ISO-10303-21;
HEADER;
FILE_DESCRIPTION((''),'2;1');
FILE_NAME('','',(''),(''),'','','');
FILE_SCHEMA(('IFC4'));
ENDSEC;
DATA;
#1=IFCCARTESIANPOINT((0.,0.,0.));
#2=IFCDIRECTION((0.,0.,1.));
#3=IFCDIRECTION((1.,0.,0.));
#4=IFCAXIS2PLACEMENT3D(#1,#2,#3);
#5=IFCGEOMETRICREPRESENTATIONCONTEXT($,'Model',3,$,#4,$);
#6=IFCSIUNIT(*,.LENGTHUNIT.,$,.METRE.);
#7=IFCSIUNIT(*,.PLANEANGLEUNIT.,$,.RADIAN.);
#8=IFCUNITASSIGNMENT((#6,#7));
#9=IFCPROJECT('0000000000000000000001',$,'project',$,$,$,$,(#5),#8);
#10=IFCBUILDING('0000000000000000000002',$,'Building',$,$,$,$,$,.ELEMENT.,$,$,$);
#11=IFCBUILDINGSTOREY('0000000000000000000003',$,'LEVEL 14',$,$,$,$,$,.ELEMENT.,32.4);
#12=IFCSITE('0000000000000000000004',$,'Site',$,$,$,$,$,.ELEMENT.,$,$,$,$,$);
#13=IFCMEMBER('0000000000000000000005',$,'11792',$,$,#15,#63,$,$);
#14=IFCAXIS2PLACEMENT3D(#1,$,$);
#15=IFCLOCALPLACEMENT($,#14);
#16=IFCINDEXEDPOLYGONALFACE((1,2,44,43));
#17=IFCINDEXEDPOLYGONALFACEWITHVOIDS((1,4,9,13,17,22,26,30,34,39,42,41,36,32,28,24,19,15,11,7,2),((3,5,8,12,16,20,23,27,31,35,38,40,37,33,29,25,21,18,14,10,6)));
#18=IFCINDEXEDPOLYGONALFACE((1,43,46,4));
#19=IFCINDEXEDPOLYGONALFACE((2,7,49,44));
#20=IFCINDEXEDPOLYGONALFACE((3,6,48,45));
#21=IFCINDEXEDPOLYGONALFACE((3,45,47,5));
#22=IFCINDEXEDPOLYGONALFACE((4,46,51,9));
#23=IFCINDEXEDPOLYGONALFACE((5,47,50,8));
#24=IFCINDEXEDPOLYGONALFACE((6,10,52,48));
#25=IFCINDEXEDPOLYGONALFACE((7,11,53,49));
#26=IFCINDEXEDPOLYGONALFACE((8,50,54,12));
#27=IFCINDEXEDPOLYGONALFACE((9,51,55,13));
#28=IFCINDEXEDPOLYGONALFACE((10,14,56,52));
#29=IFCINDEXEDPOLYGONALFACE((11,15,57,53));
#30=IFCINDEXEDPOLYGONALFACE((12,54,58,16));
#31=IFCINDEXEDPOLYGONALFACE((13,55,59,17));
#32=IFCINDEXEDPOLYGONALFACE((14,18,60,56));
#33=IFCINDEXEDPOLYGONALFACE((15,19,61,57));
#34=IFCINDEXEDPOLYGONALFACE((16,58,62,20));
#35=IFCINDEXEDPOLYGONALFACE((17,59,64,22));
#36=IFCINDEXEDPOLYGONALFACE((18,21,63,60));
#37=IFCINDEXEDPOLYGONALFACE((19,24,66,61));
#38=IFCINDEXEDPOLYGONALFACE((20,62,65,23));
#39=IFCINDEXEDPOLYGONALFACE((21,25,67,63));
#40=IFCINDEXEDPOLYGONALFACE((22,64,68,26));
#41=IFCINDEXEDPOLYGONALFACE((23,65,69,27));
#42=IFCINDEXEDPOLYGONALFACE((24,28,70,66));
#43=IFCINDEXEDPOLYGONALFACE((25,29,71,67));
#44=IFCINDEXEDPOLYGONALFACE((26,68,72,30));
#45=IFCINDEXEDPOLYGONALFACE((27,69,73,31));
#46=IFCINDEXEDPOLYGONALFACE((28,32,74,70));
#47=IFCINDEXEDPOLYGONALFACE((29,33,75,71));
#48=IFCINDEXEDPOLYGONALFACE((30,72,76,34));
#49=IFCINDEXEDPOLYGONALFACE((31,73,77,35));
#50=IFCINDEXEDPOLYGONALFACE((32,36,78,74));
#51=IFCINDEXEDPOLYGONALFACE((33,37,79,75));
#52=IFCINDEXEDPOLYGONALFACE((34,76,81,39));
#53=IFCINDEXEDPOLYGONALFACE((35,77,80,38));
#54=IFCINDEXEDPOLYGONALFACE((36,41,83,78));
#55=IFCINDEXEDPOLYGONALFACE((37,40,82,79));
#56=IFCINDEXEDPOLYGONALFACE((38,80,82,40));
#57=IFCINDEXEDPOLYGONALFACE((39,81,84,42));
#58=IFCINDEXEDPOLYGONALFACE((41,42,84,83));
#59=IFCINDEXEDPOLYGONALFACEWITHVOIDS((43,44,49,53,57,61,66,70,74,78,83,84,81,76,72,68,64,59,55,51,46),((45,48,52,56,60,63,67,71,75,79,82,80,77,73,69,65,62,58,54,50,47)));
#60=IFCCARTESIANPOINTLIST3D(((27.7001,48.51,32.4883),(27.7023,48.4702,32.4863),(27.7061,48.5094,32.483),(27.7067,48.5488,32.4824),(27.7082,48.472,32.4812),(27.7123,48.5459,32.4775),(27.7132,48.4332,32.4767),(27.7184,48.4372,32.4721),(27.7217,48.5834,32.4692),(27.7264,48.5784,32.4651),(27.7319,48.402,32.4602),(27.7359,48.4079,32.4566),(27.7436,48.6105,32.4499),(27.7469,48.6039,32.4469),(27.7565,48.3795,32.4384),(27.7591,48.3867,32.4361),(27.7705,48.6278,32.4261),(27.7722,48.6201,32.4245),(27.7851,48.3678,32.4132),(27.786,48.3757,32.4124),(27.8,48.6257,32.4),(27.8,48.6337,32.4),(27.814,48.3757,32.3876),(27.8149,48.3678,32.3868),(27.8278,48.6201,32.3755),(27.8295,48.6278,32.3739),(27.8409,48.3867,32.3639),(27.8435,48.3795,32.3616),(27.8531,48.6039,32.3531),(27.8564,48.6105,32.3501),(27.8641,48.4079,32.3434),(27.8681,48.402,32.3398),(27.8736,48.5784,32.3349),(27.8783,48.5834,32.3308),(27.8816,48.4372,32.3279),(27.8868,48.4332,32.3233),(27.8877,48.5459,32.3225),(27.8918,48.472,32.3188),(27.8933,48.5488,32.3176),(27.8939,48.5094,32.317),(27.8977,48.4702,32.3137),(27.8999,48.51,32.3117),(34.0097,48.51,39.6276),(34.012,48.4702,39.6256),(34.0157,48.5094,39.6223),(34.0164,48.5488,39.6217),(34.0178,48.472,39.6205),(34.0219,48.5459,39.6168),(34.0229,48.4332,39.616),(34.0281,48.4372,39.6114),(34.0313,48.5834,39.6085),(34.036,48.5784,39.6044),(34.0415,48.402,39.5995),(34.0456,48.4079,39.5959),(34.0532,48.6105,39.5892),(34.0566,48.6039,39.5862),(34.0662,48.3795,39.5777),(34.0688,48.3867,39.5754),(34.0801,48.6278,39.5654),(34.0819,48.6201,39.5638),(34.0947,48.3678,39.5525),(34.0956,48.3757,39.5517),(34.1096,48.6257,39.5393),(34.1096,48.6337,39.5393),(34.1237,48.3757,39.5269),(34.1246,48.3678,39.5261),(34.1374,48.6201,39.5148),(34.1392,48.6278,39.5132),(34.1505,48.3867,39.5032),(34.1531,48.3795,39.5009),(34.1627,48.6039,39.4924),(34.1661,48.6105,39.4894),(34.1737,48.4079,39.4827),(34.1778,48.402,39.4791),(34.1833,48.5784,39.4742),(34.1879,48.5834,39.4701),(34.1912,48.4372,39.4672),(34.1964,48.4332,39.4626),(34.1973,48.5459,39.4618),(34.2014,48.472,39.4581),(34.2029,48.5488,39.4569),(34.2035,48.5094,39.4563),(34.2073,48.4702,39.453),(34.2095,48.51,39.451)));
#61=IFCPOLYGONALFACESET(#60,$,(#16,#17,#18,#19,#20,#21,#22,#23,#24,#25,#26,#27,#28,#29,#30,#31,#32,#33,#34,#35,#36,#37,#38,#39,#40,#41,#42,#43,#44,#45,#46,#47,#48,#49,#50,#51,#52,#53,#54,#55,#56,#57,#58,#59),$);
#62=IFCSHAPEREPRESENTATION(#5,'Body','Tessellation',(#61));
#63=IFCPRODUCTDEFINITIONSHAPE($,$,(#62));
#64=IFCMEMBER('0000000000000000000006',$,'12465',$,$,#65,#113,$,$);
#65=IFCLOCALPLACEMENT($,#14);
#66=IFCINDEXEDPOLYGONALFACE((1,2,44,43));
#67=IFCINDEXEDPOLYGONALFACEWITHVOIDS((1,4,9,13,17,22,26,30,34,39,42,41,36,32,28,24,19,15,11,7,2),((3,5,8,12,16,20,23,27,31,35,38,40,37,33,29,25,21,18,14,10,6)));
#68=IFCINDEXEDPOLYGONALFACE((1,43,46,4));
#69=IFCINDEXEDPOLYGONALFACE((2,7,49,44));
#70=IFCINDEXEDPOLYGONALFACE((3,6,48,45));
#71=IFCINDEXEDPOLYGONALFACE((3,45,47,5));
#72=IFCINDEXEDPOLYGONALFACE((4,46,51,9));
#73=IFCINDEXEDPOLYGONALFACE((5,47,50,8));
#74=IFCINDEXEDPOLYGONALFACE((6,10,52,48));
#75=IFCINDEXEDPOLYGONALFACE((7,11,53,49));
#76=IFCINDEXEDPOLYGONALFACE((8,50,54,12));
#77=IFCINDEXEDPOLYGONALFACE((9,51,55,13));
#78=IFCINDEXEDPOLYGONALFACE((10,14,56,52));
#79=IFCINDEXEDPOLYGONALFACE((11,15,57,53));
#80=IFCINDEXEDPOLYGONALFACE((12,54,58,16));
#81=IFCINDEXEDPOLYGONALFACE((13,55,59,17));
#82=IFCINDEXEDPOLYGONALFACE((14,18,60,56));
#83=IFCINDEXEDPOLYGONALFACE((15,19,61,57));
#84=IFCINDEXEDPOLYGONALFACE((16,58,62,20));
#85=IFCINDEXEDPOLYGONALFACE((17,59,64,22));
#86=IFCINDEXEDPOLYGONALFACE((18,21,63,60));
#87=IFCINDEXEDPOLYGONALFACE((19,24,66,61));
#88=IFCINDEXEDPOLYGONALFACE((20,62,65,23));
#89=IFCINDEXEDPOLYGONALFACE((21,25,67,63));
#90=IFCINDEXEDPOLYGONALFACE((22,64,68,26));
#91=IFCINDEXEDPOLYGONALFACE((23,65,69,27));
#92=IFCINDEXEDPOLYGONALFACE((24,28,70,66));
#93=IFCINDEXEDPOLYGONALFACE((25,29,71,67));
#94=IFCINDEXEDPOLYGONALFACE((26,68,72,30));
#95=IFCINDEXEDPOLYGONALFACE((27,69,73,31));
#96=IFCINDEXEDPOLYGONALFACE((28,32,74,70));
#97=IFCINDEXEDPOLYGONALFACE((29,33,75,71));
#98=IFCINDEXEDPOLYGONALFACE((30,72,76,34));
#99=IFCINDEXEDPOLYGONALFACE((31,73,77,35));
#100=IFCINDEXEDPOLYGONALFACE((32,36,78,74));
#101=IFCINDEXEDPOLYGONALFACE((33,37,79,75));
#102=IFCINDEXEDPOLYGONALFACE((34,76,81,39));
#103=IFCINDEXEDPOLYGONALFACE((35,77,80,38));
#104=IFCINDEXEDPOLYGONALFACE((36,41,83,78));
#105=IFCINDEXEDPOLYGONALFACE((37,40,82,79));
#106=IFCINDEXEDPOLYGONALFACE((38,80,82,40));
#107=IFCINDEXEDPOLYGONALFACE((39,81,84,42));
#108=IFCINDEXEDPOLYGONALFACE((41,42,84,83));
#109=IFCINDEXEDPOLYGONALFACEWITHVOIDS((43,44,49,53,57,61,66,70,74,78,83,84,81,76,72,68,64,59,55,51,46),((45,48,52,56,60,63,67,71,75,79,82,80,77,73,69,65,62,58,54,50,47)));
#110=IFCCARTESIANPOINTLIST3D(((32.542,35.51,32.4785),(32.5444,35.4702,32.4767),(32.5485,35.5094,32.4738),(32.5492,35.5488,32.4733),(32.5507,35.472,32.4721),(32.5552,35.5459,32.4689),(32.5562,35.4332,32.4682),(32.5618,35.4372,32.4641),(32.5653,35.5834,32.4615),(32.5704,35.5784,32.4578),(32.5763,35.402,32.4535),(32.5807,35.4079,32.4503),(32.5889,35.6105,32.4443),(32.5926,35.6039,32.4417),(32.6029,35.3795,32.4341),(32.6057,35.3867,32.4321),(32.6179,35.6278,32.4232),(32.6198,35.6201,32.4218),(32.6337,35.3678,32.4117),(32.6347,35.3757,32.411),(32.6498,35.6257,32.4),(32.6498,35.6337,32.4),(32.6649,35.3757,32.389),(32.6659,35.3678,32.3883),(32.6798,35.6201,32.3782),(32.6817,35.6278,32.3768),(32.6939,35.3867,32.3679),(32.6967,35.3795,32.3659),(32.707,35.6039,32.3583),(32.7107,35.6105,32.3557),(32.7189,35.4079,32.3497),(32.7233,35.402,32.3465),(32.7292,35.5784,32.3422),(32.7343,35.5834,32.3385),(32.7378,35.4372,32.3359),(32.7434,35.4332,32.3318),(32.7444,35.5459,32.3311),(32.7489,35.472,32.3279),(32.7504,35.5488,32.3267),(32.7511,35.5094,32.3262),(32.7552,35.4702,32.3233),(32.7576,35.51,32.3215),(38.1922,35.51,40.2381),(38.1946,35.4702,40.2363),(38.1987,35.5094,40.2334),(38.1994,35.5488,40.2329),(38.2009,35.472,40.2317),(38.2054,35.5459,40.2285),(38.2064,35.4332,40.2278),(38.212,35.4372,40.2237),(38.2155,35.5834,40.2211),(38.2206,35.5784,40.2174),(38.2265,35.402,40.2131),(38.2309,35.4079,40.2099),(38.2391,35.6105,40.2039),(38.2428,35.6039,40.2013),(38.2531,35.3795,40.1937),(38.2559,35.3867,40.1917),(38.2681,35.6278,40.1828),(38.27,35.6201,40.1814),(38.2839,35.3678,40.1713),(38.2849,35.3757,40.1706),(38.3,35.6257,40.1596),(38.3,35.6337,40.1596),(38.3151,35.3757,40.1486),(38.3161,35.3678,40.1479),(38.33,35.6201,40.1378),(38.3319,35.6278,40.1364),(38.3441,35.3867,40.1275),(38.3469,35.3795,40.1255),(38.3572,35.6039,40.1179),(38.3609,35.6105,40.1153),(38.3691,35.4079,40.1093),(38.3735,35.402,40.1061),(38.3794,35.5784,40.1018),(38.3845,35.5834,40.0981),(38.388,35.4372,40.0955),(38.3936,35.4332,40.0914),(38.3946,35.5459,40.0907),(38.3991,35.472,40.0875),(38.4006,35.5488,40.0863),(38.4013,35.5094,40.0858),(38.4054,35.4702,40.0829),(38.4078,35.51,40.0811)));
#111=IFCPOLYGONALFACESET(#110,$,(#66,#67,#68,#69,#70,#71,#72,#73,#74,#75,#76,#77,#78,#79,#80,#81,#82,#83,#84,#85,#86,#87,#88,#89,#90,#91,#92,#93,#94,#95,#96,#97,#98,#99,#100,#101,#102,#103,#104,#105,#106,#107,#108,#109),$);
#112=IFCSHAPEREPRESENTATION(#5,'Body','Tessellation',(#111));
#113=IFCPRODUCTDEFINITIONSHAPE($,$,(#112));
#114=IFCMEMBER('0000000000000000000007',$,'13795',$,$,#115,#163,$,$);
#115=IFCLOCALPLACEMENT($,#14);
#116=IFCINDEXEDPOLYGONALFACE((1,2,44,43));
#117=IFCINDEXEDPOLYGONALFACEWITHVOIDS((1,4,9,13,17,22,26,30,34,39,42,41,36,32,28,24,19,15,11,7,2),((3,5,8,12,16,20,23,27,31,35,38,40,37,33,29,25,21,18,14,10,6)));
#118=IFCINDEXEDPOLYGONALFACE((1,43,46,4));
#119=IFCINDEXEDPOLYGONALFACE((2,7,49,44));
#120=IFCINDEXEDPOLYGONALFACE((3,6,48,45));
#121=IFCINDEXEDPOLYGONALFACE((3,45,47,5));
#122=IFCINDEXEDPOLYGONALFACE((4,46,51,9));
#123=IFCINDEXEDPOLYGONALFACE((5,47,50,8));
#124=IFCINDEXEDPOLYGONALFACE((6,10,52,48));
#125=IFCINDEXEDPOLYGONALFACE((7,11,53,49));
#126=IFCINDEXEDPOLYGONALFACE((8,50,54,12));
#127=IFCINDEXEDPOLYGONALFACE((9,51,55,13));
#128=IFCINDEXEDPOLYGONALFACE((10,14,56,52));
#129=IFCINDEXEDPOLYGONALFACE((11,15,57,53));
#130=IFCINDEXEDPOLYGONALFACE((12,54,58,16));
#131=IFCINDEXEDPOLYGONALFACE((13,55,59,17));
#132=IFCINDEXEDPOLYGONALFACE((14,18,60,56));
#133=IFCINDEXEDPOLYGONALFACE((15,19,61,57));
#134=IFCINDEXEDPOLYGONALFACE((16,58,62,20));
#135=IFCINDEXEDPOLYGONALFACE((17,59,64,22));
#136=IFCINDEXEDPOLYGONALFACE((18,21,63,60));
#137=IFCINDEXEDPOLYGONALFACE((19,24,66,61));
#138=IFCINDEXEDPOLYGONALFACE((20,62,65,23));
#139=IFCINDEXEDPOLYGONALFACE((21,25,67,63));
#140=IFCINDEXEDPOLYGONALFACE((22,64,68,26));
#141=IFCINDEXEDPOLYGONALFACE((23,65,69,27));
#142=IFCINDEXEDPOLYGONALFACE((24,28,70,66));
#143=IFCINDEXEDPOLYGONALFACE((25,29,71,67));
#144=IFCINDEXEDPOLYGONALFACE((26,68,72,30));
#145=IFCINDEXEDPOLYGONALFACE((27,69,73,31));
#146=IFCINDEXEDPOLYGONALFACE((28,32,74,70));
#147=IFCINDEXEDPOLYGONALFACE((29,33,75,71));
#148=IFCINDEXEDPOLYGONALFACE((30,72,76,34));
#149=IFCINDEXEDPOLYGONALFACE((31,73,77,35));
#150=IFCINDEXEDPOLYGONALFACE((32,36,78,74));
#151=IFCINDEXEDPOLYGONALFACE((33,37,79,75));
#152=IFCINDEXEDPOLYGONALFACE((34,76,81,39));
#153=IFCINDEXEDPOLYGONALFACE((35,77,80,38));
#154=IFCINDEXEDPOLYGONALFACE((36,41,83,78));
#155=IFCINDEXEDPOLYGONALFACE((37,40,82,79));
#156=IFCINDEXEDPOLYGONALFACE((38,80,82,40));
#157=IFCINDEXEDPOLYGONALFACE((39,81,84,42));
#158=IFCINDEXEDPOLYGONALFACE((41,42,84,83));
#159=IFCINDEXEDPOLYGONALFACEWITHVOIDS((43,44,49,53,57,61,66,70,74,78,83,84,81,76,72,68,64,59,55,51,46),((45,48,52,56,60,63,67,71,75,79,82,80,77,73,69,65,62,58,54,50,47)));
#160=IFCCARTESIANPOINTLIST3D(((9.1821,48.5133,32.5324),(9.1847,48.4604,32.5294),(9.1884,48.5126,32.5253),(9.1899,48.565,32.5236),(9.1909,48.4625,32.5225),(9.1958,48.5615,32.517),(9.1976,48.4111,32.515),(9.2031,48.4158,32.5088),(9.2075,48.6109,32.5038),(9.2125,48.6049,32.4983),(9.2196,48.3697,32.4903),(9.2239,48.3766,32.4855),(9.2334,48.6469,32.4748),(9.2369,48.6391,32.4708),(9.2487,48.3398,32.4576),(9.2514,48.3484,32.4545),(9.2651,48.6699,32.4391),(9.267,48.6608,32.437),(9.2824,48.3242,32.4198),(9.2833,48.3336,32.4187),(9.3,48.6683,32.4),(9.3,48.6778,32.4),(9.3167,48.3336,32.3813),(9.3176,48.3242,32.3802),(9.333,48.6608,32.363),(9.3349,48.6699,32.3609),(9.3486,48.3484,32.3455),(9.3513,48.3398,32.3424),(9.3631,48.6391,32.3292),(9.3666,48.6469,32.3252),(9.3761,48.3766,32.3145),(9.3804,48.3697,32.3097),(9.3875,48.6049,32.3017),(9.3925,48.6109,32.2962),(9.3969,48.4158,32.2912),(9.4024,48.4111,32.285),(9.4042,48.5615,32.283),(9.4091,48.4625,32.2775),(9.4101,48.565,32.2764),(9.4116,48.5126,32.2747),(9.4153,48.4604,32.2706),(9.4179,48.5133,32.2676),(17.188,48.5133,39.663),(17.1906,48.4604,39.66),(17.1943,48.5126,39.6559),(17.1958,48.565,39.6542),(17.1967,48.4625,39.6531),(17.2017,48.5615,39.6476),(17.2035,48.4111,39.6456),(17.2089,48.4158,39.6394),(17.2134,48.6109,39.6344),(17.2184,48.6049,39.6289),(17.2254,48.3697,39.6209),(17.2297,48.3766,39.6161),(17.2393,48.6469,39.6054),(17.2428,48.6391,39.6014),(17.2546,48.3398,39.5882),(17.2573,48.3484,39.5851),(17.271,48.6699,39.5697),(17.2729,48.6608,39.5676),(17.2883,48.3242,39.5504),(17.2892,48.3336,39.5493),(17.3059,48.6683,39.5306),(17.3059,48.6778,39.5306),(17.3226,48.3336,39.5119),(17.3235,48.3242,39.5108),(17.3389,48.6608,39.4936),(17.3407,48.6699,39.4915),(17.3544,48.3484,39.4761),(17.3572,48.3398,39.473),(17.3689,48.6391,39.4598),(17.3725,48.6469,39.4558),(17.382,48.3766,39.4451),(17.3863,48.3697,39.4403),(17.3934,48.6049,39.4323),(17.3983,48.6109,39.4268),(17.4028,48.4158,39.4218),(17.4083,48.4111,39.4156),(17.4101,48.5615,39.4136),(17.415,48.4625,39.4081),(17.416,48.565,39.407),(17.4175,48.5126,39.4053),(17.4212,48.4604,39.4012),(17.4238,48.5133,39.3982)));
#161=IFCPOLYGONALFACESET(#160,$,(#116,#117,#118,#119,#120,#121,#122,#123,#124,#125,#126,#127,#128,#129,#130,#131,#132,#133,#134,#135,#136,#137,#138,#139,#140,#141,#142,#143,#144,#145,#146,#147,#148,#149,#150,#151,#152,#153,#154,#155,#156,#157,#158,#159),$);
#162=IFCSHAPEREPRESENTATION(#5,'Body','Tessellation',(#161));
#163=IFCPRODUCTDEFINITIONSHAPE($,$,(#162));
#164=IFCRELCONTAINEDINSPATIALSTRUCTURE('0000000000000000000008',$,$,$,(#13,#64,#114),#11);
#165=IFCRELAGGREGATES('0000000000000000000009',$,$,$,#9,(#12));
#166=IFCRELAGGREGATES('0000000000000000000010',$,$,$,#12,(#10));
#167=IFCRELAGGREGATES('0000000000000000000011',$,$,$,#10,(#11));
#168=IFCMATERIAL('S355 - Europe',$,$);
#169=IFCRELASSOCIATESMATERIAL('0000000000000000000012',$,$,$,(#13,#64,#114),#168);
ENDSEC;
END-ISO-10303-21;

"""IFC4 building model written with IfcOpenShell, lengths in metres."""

from ifc_helpers import new_model, si_unit, frame, origin_with_axes, origin_2d_with_axis, place, context, project, spatial, hollow_circle, extrude, material, material_profile, profile_set, profile_usage, element, save


model = new_model("IFC4")

# Units and contexts
model_context = context("Model", 3, world=origin_with_axes())
ifc_project = project(units=[si_unit("LENGTHUNIT", "METRE"), si_unit("PLANEANGLEUNIT", "RADIAN")], contexts=[model_context])

# Site, building, storey
site = spatial("IfcSite", under=ifc_project, Name="Site", CompositionType="ELEMENT")
building = spatial("IfcBuilding", under=site, Name="Building", CompositionType="ELEMENT")
storey = spatial("IfcBuildingStorey", under=building, Name="LEVEL 14", CompositionType="ELEMENT", Elevation=32.4)

# Shared definitions
ifc_material = material(Name="S355 - Europe")

# Members
ifc_material_profile_1 = material_profile(ifc_material, hollow_circle(Radius=0.1337, WallThickness=0.008, at=origin_2d_with_axis()))
ifc_profile_set_1 = profile_set([ifc_material_profile_1])
ifc_profile_usage_1 = profile_usage(ifc_profile_set_1, cardinal=10)
member_1_placement = place(None, frame((27.8, 48.5, 32.4), z_axis=(0.662226, 0.0, 0.749304), x_axis=(0.0, 1.0, 0.0)))
element("IfcMember", 1, at=member_1_placement, inside=storey, material=ifc_profile_usage_1, Name="11792", context=model_context, shape_type="SweptSolid", body=[
    extrude(hollow_circle(Radius=0.1337, WallThickness=0.008, at=origin_2d_with_axis()), origin_with_axes(), (0.0, 0.0, 1.0), 9.5279),
])
ifc_material_profile_2 = material_profile(ifc_material, hollow_circle(Radius=0.1337, WallThickness=0.008, at=origin_2d_with_axis()))
ifc_profile_set_2 = profile_set([ifc_material_profile_2])
ifc_profile_usage_2 = profile_usage(ifc_profile_set_2, cardinal=10)
member_2_placement = place(None, frame((32.6498, 35.5, 32.4), z_axis=(0.588639, 0.0, 0.808396), x_axis=(0.0, 1.0, 0.0)))
element("IfcMember", 2, at=member_2_placement, inside=storey, material=ifc_profile_usage_2, Name="12465", context=model_context, shape_type="SweptSolid", body=[
    extrude(hollow_circle(Radius=0.1337, WallThickness=0.008, at=origin_2d_with_axis()), origin_with_axes(), (0.0, 0.0, 1.0), 9.5988),
])
ifc_material_profile_3 = material_profile(ifc_material, hollow_circle(Radius=0.1778, WallThickness=0.0095, at=origin_2d_with_axis()))
ifc_profile_set_3 = profile_set([ifc_material_profile_3])
ifc_profile_usage_3 = profile_usage(ifc_profile_set_3, cardinal=10)
member_3_placement = place(None, frame((9.3, 48.5, 32.4), z_axis=(0.746748, 0.0, 0.665107), x_axis=(0.0, 1.0, 0.0)))
element("IfcMember", 3, at=member_3_placement, inside=storey, material=ifc_profile_usage_3, Name="13795", context=model_context, shape_type="SweptSolid", body=[
    extrude(hollow_circle(Radius=0.1778, WallThickness=0.0095, at=origin_2d_with_axis()), origin_with_axes(), (0.0, 0.0, 1.0), 10.721),
])

save(model, "model.ifc")
